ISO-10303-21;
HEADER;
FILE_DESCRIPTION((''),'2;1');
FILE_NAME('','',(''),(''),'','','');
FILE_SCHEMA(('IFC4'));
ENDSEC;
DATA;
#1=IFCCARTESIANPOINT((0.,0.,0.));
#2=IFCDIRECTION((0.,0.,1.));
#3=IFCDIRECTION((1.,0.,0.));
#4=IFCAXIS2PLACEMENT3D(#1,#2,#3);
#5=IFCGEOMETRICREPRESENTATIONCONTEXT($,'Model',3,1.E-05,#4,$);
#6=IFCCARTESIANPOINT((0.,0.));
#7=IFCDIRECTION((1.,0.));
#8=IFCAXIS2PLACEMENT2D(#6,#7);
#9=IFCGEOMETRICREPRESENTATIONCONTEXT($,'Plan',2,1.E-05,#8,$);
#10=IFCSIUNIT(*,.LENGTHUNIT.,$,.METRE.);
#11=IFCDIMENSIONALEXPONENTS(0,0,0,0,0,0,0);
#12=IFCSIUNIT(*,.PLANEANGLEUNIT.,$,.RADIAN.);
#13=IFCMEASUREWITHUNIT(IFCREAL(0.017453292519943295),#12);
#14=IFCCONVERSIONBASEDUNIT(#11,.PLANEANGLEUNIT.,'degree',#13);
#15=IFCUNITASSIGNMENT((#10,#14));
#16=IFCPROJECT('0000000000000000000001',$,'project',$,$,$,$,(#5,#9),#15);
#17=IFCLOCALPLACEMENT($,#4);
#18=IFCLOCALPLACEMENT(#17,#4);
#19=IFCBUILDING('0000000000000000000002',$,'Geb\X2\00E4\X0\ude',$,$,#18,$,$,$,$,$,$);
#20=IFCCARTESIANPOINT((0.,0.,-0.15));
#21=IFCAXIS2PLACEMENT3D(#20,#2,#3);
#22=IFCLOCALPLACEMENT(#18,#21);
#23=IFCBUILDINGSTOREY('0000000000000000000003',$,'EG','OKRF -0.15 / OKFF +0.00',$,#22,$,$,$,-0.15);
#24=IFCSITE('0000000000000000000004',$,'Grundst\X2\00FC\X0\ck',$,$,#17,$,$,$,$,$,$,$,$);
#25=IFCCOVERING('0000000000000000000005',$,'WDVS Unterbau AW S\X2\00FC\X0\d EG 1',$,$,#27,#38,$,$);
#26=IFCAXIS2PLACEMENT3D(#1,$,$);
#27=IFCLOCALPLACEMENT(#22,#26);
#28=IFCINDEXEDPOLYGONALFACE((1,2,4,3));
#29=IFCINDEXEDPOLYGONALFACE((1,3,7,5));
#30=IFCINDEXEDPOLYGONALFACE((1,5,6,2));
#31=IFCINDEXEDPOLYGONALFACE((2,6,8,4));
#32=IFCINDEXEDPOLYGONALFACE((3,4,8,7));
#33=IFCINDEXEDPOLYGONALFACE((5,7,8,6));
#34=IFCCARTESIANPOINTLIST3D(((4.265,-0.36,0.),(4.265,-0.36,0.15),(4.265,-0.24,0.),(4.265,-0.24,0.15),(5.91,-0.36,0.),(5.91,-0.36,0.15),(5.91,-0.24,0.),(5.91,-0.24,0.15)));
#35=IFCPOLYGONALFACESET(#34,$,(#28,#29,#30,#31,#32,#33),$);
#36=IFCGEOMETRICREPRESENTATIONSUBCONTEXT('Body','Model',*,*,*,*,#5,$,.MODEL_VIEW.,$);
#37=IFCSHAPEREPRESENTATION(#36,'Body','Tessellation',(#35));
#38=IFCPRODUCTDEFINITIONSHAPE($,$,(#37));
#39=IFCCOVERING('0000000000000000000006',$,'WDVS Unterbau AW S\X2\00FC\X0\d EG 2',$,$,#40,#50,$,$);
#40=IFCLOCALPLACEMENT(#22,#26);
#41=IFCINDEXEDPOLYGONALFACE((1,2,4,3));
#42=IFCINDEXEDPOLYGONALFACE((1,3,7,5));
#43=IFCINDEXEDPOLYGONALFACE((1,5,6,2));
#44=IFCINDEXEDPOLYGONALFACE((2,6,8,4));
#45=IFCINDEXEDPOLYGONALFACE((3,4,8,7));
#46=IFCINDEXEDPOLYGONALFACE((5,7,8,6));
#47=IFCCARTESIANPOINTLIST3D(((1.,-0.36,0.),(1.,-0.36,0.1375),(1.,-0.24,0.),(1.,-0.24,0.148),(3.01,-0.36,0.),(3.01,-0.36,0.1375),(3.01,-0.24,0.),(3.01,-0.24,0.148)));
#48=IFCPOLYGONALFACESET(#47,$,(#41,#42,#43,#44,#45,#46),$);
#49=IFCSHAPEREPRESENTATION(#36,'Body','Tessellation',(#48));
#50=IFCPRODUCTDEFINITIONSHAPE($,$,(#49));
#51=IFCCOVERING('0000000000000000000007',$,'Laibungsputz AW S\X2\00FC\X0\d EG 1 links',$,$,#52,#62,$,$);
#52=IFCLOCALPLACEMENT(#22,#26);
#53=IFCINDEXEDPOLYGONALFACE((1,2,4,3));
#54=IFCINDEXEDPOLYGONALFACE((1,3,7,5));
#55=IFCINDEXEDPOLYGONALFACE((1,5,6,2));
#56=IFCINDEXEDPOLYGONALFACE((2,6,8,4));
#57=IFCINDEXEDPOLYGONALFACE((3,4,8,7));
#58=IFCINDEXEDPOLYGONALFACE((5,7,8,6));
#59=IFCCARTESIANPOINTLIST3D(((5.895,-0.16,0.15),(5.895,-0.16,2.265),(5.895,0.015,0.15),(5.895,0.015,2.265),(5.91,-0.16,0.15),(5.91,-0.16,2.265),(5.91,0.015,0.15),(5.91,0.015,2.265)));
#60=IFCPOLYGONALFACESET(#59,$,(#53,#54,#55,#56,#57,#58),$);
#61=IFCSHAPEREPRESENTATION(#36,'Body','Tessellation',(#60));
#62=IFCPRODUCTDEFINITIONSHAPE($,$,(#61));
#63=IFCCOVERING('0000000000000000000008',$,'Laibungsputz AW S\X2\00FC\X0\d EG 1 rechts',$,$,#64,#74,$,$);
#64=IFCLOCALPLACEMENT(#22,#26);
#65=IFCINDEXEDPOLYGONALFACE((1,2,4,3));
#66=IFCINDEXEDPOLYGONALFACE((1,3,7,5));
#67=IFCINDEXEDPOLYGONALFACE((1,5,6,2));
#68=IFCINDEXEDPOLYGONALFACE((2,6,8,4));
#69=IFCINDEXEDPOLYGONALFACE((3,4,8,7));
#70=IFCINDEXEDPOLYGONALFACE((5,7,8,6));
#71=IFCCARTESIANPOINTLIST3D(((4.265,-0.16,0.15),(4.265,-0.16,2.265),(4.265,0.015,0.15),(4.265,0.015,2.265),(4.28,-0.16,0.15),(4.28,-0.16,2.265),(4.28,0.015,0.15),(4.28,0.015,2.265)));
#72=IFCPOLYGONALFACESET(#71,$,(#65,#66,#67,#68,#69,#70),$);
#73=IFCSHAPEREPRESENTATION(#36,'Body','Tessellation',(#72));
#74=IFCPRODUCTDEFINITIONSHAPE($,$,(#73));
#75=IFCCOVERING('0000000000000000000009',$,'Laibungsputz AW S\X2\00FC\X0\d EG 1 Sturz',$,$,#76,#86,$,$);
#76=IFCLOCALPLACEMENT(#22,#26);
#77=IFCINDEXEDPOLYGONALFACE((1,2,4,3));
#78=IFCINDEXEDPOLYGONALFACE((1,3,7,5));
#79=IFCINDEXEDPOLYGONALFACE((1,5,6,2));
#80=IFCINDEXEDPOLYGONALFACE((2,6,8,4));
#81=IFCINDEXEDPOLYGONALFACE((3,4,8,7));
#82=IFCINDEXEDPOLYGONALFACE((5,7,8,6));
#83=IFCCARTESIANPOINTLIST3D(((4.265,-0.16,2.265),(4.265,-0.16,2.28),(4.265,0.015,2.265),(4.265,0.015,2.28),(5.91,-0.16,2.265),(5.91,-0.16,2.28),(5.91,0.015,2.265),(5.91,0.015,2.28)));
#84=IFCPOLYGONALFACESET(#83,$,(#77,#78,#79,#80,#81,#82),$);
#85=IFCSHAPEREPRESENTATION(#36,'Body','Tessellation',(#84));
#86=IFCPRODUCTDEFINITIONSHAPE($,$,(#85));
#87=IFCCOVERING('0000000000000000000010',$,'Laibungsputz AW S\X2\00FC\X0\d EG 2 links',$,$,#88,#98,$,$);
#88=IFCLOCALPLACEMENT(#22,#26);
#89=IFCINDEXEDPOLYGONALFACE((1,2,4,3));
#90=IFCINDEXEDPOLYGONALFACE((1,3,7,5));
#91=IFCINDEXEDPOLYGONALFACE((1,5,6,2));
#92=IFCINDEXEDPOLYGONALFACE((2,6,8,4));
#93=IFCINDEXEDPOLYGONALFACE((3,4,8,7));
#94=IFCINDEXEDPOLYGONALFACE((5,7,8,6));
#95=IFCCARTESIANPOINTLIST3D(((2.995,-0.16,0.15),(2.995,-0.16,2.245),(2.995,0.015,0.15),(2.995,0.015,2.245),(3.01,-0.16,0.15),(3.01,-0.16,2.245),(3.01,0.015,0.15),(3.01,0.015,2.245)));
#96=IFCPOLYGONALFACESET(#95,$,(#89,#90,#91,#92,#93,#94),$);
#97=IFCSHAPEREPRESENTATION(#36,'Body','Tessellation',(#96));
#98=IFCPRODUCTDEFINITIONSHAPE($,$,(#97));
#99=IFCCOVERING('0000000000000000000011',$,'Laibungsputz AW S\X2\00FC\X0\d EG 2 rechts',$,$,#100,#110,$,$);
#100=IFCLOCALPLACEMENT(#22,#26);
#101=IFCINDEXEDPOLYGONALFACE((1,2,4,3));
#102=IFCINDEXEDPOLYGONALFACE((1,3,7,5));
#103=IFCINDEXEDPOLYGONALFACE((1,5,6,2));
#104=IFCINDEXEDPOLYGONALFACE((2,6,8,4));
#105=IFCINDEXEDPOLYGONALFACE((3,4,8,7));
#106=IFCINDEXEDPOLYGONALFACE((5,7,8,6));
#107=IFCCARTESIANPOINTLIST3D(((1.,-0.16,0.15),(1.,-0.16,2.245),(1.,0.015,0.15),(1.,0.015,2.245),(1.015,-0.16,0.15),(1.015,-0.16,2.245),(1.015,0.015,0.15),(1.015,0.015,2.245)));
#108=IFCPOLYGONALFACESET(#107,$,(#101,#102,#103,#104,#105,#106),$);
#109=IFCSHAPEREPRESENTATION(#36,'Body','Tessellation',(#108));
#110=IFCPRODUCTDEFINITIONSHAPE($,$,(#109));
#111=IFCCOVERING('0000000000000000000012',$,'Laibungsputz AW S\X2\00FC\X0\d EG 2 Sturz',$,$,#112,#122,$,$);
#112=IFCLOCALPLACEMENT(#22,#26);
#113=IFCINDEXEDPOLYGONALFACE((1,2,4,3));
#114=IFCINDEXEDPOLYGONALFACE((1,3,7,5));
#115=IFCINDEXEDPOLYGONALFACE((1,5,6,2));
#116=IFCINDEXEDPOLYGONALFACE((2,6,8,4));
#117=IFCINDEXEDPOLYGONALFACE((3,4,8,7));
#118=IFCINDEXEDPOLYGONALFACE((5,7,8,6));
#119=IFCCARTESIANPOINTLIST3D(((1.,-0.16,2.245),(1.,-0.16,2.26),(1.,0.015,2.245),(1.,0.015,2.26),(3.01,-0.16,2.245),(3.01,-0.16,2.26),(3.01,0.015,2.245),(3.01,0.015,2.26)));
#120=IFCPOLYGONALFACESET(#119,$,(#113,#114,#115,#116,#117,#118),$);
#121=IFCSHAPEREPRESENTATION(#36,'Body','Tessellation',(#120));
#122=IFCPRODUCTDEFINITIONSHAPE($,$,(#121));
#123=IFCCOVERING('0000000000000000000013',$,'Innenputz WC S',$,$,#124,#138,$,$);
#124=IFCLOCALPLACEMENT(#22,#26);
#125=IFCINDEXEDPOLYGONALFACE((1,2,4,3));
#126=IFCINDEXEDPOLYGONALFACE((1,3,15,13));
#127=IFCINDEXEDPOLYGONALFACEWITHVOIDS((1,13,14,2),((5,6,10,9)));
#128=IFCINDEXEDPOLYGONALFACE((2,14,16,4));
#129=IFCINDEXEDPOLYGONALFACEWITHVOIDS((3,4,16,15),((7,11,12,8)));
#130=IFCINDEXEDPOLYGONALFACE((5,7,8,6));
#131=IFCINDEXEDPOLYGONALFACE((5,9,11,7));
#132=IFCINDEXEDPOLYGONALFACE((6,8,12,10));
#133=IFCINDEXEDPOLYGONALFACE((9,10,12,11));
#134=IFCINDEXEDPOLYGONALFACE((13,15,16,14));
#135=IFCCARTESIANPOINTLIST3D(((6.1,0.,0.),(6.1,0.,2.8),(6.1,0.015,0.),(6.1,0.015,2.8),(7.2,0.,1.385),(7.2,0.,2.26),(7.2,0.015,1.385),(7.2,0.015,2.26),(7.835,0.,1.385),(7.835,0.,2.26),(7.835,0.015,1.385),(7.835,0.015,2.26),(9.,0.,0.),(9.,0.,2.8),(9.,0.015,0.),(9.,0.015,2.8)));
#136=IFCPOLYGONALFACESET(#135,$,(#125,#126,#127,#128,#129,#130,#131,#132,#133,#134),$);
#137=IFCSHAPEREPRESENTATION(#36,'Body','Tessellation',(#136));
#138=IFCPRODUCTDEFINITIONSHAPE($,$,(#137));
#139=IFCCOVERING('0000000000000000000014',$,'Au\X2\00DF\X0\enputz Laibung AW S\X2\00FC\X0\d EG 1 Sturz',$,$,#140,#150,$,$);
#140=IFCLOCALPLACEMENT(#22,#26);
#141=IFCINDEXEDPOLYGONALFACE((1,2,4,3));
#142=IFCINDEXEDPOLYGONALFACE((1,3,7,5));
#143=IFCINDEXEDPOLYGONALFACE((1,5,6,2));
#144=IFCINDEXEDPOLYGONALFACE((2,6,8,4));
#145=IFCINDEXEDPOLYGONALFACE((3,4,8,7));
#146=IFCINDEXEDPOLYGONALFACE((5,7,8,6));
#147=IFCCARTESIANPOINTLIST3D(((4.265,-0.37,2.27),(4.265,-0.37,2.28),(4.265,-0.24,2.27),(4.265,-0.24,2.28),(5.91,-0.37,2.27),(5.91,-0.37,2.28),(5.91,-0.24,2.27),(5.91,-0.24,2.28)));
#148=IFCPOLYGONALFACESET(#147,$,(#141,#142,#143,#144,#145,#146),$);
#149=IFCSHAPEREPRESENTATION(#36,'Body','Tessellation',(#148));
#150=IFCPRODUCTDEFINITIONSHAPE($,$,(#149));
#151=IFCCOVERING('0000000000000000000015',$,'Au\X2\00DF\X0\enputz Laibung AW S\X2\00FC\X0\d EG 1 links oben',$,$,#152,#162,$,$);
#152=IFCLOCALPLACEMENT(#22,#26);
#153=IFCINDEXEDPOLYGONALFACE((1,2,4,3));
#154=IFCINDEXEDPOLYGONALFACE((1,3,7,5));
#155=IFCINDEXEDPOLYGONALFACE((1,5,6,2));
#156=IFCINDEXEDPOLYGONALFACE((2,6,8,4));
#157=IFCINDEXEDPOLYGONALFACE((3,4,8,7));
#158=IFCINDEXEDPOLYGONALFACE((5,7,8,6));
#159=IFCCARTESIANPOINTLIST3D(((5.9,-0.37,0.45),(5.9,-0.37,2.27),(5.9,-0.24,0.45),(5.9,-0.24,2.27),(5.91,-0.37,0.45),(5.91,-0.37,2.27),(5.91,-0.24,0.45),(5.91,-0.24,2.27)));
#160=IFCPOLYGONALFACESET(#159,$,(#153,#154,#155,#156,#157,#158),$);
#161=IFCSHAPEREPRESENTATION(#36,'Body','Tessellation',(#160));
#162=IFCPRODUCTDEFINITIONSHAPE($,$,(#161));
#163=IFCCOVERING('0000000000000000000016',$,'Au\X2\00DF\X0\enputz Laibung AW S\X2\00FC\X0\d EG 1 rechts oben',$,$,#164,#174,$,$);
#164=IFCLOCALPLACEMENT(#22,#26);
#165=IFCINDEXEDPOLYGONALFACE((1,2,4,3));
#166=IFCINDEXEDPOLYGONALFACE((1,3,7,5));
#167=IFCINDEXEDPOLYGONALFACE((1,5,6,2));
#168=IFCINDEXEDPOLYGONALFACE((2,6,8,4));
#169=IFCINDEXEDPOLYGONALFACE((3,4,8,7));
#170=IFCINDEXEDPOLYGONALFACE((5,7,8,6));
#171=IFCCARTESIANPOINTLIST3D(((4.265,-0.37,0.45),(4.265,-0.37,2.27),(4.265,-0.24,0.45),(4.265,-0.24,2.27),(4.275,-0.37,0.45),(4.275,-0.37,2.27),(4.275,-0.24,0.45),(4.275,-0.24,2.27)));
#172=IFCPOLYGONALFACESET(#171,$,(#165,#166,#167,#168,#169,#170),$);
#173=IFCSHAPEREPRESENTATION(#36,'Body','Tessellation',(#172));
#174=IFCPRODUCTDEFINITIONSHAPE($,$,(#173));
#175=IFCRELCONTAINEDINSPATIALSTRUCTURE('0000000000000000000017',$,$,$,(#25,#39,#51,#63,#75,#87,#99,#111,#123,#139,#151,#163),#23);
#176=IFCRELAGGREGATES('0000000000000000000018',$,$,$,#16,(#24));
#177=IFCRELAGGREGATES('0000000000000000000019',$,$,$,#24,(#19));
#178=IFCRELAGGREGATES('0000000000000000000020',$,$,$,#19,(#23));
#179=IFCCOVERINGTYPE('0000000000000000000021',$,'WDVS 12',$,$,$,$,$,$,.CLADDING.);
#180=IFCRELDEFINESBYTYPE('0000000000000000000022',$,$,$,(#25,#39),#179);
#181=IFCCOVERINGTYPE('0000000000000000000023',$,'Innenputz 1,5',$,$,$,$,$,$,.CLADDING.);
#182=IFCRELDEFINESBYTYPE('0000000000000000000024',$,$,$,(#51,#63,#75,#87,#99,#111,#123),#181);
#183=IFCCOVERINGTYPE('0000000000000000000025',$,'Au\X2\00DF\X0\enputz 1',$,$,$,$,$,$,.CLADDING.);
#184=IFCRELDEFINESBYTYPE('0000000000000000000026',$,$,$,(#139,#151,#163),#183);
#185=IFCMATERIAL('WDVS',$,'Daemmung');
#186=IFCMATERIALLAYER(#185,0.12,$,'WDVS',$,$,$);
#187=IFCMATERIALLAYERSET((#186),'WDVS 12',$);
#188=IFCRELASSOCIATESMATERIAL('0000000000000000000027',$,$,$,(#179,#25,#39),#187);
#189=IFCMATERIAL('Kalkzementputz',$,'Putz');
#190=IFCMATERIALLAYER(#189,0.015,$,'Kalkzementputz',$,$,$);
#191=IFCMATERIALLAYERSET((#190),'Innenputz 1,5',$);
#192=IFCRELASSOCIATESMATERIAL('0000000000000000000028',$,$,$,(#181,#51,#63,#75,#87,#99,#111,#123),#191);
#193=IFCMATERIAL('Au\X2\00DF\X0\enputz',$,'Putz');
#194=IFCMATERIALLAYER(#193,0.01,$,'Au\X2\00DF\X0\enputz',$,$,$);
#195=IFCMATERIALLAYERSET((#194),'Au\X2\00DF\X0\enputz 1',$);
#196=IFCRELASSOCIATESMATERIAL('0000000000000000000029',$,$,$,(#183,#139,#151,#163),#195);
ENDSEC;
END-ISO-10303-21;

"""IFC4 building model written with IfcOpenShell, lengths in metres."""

from ifc_helpers import new_model, entity, si_unit, converted_unit, frame, origin_with_axes, origin_2d_with_axis, place, context, subcontext, project, spatial, polyline, indexed_curve, outline, extrude, material, layer, layer_set, layer_usage, type_object, element, save


model = new_model("IFC4")

# Units and contexts
model_context = context("Model", 3, precision=1e-05, world=origin_with_axes())
plan_context = context("Plan", 2, precision=1e-05, world=origin_2d_with_axis())
body_context_1 = subcontext(model_context, "Body", "Model", "MODEL_VIEW")
ifc_project = project(units=[si_unit("LENGTHUNIT", "METRE"), converted_unit("PLANEANGLEUNIT", "degree", entity("IfcReal", 0.017453292519943295), si_unit("PLANEANGLEUNIT", "RADIAN"), dimensions=[0, 0, 0, 0, 0, 0, 0])], contexts=[model_context, plan_context])

# Site, building, storey
site_placement = place(None, origin_with_axes())
site = spatial("IfcSite", under=ifc_project, at=site_placement, Name="Grundstück")
building_placement = place(site_placement, origin_with_axes())
building = spatial("IfcBuilding", under=site, at=building_placement, Name="Gebäude")
storey_placement = place(building_placement, frame((0.0, 0.0, -0.15), z_axis=(0.0, 0.0, 1.0), x_axis=(1.0, 0.0, 0.0)))
storey = spatial("IfcBuildingStorey", under=building, at=storey_placement, Name="EG", Description="OKRF -0.15 / OKFF +0.00", Elevation=-0.15)

# Shared definitions
ifc_material_1 = material(Name="WDVS", Category="Daemmung")

# Coverings
ifc_layer_1 = layer(ifc_material_1, 0.12, Name="WDVS")
ifc_layer_set_1 = layer_set([ifc_layer_1], Name="WDVS 12")
ifc_layer_usage_1 = layer_usage(ifc_layer_set_1, "AXIS2", "POSITIVE", 0.24)
covering_type_1 = type_object("IfcCoveringType", Name="WDVS 12", PredefinedType="CLADDING", material=ifc_layer_set_1)
covering_1_placement = place(storey_placement, frame((9.0, 0.0, 0.0), z_axis=(0.0, 0.0, 1.0), x_axis=(-1.0, 0.0, 0.0)))
element("IfcCovering", 1, at=covering_1_placement, inside=storey, type_object=covering_type_1, material=ifc_layer_usage_1, Name="WDVS Unterbau AW Süd EG 1", context=body_context_1, shape_type="SweptSolid", body=[
    extrude(outline(polyline([(0.24, 0.0), (0.36, 0.0), (0.36, 0.15), (0.24, 0.15), (0.24, 0.0)])), frame((3.09, 0.0, 0.0), z_axis=(1.0, 0.0, 0.0), x_axis=(0.0, 1.0, 0.0)), (0.0, 0.0, 1.0), 1.645),
])
ifc_layer_usage_2 = layer_usage(ifc_layer_set_1, "AXIS2", "POSITIVE", 0.24)
covering_2_placement = place(storey_placement, frame((9.0, 0.0, 0.0), z_axis=(0.0, 0.0, 1.0), x_axis=(-1.0, 0.0, 0.0)))
element("IfcCovering", 2, at=covering_2_placement, inside=storey, type_object=covering_type_1, material=ifc_layer_usage_2, Name="WDVS Unterbau AW Süd EG 2", context=body_context_1, shape_type="SweptSolid", body=[
    extrude(outline(polyline([(0.24, 0.0), (0.36, 0.0), (0.36, 0.1375), (0.24, 0.148), (0.24, 0.0)])), frame((5.99, 0.0, 0.0), z_axis=(1.0, 0.0, 0.0), x_axis=(0.0, 1.0, 0.0)), (0.0, 0.0, 1.0), 2.01),
])
ifc_material_2 = material(Name="Kalkzementputz", Category="Putz")
ifc_layer_2 = layer(ifc_material_2, 0.015, Name="Kalkzementputz")
ifc_layer_set_2 = layer_set([ifc_layer_2], Name="Innenputz 1,5")
ifc_layer_usage_3 = layer_usage(ifc_layer_set_2, "AXIS1", "POSITIVE", 3.09)
covering_type_2 = type_object("IfcCoveringType", Name="Innenputz 1,5", PredefinedType="CLADDING", material=ifc_layer_set_2)
covering_3_placement = place(storey_placement, frame((9.0, 0.0, 0.0), z_axis=(0.0, 0.0, 1.0), x_axis=(-1.0, 0.0, 0.0)))
element("IfcCovering", 3, at=covering_3_placement, inside=storey, type_object=covering_type_2, material=ifc_layer_usage_3, Name="Laibungsputz AW Süd EG 1 links", context=body_context_1, shape_type="SweptSolid", body=[
    extrude(outline(polyline([(-0.015, 0.15), (0.16, 0.15), (0.16, 2.265), (-0.015, 2.265), (-0.015, 0.15)])), frame((3.09, 0.0, 0.0), z_axis=(1.0, 0.0, 0.0), x_axis=(0.0, 1.0, 0.0)), (0.0, 0.0, 1.0), 0.015),
])
ifc_layer_usage_4 = layer_usage(ifc_layer_set_2, "AXIS1", "POSITIVE", 4.72)
covering_4_placement = place(storey_placement, frame((9.0, 0.0, 0.0), z_axis=(0.0, 0.0, 1.0), x_axis=(-1.0, 0.0, 0.0)))
element("IfcCovering", 4, at=covering_4_placement, inside=storey, type_object=covering_type_2, material=ifc_layer_usage_4, Name="Laibungsputz AW Süd EG 1 rechts", context=body_context_1, shape_type="SweptSolid", body=[
    extrude(outline(polyline([(-0.015, 0.15), (0.16, 0.15), (0.16, 2.265), (-0.015, 2.265), (-0.015, 0.15)])), frame((4.72, 0.0, 0.0), z_axis=(1.0, 0.0, 0.0), x_axis=(0.0, 1.0, 0.0)), (0.0, 0.0, 1.0), 0.015),
])
ifc_layer_usage_5 = layer_usage(ifc_layer_set_2, "AXIS3", "POSITIVE", 2.265)
covering_5_placement = place(storey_placement, frame((9.0, 0.0, 0.0), z_axis=(0.0, 0.0, 1.0), x_axis=(-1.0, 0.0, 0.0)))
element("IfcCovering", 5, at=covering_5_placement, inside=storey, type_object=covering_type_2, material=ifc_layer_usage_5, Name="Laibungsputz AW Süd EG 1 Sturz", context=body_context_1, shape_type="SweptSolid", body=[
    extrude(outline(polyline([(-0.015, 2.265), (0.16, 2.265), (0.16, 2.28), (-0.015, 2.28), (-0.015, 2.265)])), frame((3.09, 0.0, 0.0), z_axis=(1.0, 0.0, 0.0), x_axis=(0.0, 1.0, 0.0)), (0.0, 0.0, 1.0), 1.645),
])
ifc_layer_usage_6 = layer_usage(ifc_layer_set_2, "AXIS1", "POSITIVE", 5.99)
covering_6_placement = place(storey_placement, frame((9.0, 0.0, 0.0), z_axis=(0.0, 0.0, 1.0), x_axis=(-1.0, 0.0, 0.0)))
element("IfcCovering", 6, at=covering_6_placement, inside=storey, type_object=covering_type_2, material=ifc_layer_usage_6, Name="Laibungsputz AW Süd EG 2 links", context=body_context_1, shape_type="SweptSolid", body=[
    extrude(outline(polyline([(-0.015, 0.15), (0.16, 0.15), (0.16, 2.245), (-0.015, 2.245), (-0.015, 0.15)])), frame((5.99, 0.0, 0.0), z_axis=(1.0, 0.0, 0.0), x_axis=(0.0, 1.0, 0.0)), (0.0, 0.0, 1.0), 0.015),
])
ifc_layer_usage_7 = layer_usage(ifc_layer_set_2, "AXIS1", "POSITIVE", 7.985)
covering_7_placement = place(storey_placement, frame((9.0, 0.0, 0.0), z_axis=(0.0, 0.0, 1.0), x_axis=(-1.0, 0.0, 0.0)))
element("IfcCovering", 7, at=covering_7_placement, inside=storey, type_object=covering_type_2, material=ifc_layer_usage_7, Name="Laibungsputz AW Süd EG 2 rechts", context=body_context_1, shape_type="SweptSolid", body=[
    extrude(outline(polyline([(-0.015, 0.15), (0.16, 0.15), (0.16, 2.245), (-0.015, 2.245), (-0.015, 0.15)])), frame((7.985, 0.0, 0.0), z_axis=(1.0, 0.0, 0.0), x_axis=(0.0, 1.0, 0.0)), (0.0, 0.0, 1.0), 0.015),
])
ifc_layer_usage_8 = layer_usage(ifc_layer_set_2, "AXIS3", "POSITIVE", 2.245)
covering_8_placement = place(storey_placement, frame((9.0, 0.0, 0.0), z_axis=(0.0, 0.0, 1.0), x_axis=(-1.0, 0.0, 0.0)))
element("IfcCovering", 8, at=covering_8_placement, inside=storey, type_object=covering_type_2, material=ifc_layer_usage_8, Name="Laibungsputz AW Süd EG 2 Sturz", context=body_context_1, shape_type="SweptSolid", body=[
    extrude(outline(polyline([(-0.015, 2.245), (0.16, 2.245), (0.16, 2.26), (-0.015, 2.26), (-0.015, 2.245)])), frame((5.99, 0.0, 0.0), z_axis=(1.0, 0.0, 0.0), x_axis=(0.0, 1.0, 0.0)), (0.0, 0.0, 1.0), 2.01),
])

# Covering, opening
ifc_layer_usage_9 = layer_usage(ifc_layer_set_2, "AXIS2", "POSITIVE", 0.0)
covering_9_placement = place(storey_placement, frame((6.1, 0.0, 0.0), z_axis=(0.0, 0.0, 1.0), x_axis=(1.0, 0.0, 0.0)))
covering_9 = element("IfcCovering", 9, at=covering_9_placement, inside=storey, type_object=covering_type_2, material=ifc_layer_usage_9, Name="Innenputz WC S", context=body_context_1, shape_type="SweptSolid", body=[
    extrude(outline(indexed_curve([(0.0, 0.0), (0.0, 0.015), (2.9, 0.015), (2.9, 0.0), (0.0, 0.0)], self_intersect=False)), origin_with_axes(), (0.0, 0.0, 1.0), 2.8),
])
opening_1_placement = place(covering_9_placement, frame((1.1, -0.05, 1.385), z_axis=(0.0, 0.0, 1.0), x_axis=(1.0, 0.0, 0.0)))
element("IfcOpeningElement", 10, at=opening_1_placement, cuts=covering_9, context=body_context_1, shape_type="SweptSolid", body=[
    extrude(outline(indexed_curve([(0.0, 0.0), (0.0, 0.115), (0.635, 0.115), (0.635, 0.0), (0.0, 0.0)], self_intersect=False)), origin_with_axes(), (0.0, 0.0, 1.0), 0.875),
])

# Coverings
ifc_material_3 = material(Name="Außenputz", Category="Putz")
ifc_layer_3 = layer(ifc_material_3, 0.01, Name="Außenputz")
ifc_layer_set_3 = layer_set([ifc_layer_3], Name="Außenputz 1")
ifc_layer_usage_10 = layer_usage(ifc_layer_set_3, "AXIS3", "POSITIVE", 2.27)
covering_type_3 = type_object("IfcCoveringType", Name="Außenputz 1", PredefinedType="CLADDING", material=ifc_layer_set_3)
covering_10_placement = place(storey_placement, frame((9.0, 0.0, 0.0), z_axis=(0.0, 0.0, 1.0), x_axis=(-1.0, 0.0, 0.0)))
element("IfcCovering", 11, at=covering_10_placement, inside=storey, type_object=covering_type_3, material=ifc_layer_usage_10, Name="Außenputz Laibung AW Süd EG 1 Sturz", context=body_context_1, shape_type="SweptSolid", body=[
    extrude(outline(polyline([(0.24, 2.27), (0.37, 2.27), (0.37, 2.28), (0.24, 2.28), (0.24, 2.27)])), frame((3.09, 0.0, 0.0), z_axis=(1.0, 0.0, 0.0), x_axis=(0.0, 1.0, 0.0)), (0.0, 0.0, 1.0), 1.645),
])
ifc_layer_usage_11 = layer_usage(ifc_layer_set_3, "AXIS1", "POSITIVE", 3.09)
covering_11_placement = place(storey_placement, frame((9.0, 0.0, 0.0), z_axis=(0.0, 0.0, 1.0), x_axis=(-1.0, 0.0, 0.0)))
element("IfcCovering", 12, at=covering_11_placement, inside=storey, type_object=covering_type_3, material=ifc_layer_usage_11, Name="Außenputz Laibung AW Süd EG 1 links oben", context=body_context_1, shape_type="SweptSolid", body=[
    extrude(outline(polyline([(0.24, 0.45), (0.37, 0.45), (0.37, 2.27), (0.24, 2.27), (0.24, 0.45)])), frame((3.09, 0.0, 0.0), z_axis=(1.0, 0.0, 0.0), x_axis=(0.0, 1.0, 0.0)), (0.0, 0.0, 1.0), 0.01),
])
ifc_layer_usage_12 = layer_usage(ifc_layer_set_3, "AXIS1", "POSITIVE", 4.725)
covering_12_placement = place(storey_placement, frame((9.0, 0.0, 0.0), z_axis=(0.0, 0.0, 1.0), x_axis=(-1.0, 0.0, 0.0)))
element("IfcCovering", 13, at=covering_12_placement, inside=storey, type_object=covering_type_3, material=ifc_layer_usage_12, Name="Außenputz Laibung AW Süd EG 1 rechts oben", context=body_context_1, shape_type="SweptSolid", body=[
    extrude(outline(polyline([(0.24, 0.45), (0.37, 0.45), (0.37, 2.27), (0.24, 2.27), (0.24, 0.45)])), frame((4.725, 0.0, 0.0), z_axis=(1.0, 0.0, 0.0), x_axis=(0.0, 1.0, 0.0)), (0.0, 0.0, 1.0), 0.01),
])

save(model, "model.ifc")
